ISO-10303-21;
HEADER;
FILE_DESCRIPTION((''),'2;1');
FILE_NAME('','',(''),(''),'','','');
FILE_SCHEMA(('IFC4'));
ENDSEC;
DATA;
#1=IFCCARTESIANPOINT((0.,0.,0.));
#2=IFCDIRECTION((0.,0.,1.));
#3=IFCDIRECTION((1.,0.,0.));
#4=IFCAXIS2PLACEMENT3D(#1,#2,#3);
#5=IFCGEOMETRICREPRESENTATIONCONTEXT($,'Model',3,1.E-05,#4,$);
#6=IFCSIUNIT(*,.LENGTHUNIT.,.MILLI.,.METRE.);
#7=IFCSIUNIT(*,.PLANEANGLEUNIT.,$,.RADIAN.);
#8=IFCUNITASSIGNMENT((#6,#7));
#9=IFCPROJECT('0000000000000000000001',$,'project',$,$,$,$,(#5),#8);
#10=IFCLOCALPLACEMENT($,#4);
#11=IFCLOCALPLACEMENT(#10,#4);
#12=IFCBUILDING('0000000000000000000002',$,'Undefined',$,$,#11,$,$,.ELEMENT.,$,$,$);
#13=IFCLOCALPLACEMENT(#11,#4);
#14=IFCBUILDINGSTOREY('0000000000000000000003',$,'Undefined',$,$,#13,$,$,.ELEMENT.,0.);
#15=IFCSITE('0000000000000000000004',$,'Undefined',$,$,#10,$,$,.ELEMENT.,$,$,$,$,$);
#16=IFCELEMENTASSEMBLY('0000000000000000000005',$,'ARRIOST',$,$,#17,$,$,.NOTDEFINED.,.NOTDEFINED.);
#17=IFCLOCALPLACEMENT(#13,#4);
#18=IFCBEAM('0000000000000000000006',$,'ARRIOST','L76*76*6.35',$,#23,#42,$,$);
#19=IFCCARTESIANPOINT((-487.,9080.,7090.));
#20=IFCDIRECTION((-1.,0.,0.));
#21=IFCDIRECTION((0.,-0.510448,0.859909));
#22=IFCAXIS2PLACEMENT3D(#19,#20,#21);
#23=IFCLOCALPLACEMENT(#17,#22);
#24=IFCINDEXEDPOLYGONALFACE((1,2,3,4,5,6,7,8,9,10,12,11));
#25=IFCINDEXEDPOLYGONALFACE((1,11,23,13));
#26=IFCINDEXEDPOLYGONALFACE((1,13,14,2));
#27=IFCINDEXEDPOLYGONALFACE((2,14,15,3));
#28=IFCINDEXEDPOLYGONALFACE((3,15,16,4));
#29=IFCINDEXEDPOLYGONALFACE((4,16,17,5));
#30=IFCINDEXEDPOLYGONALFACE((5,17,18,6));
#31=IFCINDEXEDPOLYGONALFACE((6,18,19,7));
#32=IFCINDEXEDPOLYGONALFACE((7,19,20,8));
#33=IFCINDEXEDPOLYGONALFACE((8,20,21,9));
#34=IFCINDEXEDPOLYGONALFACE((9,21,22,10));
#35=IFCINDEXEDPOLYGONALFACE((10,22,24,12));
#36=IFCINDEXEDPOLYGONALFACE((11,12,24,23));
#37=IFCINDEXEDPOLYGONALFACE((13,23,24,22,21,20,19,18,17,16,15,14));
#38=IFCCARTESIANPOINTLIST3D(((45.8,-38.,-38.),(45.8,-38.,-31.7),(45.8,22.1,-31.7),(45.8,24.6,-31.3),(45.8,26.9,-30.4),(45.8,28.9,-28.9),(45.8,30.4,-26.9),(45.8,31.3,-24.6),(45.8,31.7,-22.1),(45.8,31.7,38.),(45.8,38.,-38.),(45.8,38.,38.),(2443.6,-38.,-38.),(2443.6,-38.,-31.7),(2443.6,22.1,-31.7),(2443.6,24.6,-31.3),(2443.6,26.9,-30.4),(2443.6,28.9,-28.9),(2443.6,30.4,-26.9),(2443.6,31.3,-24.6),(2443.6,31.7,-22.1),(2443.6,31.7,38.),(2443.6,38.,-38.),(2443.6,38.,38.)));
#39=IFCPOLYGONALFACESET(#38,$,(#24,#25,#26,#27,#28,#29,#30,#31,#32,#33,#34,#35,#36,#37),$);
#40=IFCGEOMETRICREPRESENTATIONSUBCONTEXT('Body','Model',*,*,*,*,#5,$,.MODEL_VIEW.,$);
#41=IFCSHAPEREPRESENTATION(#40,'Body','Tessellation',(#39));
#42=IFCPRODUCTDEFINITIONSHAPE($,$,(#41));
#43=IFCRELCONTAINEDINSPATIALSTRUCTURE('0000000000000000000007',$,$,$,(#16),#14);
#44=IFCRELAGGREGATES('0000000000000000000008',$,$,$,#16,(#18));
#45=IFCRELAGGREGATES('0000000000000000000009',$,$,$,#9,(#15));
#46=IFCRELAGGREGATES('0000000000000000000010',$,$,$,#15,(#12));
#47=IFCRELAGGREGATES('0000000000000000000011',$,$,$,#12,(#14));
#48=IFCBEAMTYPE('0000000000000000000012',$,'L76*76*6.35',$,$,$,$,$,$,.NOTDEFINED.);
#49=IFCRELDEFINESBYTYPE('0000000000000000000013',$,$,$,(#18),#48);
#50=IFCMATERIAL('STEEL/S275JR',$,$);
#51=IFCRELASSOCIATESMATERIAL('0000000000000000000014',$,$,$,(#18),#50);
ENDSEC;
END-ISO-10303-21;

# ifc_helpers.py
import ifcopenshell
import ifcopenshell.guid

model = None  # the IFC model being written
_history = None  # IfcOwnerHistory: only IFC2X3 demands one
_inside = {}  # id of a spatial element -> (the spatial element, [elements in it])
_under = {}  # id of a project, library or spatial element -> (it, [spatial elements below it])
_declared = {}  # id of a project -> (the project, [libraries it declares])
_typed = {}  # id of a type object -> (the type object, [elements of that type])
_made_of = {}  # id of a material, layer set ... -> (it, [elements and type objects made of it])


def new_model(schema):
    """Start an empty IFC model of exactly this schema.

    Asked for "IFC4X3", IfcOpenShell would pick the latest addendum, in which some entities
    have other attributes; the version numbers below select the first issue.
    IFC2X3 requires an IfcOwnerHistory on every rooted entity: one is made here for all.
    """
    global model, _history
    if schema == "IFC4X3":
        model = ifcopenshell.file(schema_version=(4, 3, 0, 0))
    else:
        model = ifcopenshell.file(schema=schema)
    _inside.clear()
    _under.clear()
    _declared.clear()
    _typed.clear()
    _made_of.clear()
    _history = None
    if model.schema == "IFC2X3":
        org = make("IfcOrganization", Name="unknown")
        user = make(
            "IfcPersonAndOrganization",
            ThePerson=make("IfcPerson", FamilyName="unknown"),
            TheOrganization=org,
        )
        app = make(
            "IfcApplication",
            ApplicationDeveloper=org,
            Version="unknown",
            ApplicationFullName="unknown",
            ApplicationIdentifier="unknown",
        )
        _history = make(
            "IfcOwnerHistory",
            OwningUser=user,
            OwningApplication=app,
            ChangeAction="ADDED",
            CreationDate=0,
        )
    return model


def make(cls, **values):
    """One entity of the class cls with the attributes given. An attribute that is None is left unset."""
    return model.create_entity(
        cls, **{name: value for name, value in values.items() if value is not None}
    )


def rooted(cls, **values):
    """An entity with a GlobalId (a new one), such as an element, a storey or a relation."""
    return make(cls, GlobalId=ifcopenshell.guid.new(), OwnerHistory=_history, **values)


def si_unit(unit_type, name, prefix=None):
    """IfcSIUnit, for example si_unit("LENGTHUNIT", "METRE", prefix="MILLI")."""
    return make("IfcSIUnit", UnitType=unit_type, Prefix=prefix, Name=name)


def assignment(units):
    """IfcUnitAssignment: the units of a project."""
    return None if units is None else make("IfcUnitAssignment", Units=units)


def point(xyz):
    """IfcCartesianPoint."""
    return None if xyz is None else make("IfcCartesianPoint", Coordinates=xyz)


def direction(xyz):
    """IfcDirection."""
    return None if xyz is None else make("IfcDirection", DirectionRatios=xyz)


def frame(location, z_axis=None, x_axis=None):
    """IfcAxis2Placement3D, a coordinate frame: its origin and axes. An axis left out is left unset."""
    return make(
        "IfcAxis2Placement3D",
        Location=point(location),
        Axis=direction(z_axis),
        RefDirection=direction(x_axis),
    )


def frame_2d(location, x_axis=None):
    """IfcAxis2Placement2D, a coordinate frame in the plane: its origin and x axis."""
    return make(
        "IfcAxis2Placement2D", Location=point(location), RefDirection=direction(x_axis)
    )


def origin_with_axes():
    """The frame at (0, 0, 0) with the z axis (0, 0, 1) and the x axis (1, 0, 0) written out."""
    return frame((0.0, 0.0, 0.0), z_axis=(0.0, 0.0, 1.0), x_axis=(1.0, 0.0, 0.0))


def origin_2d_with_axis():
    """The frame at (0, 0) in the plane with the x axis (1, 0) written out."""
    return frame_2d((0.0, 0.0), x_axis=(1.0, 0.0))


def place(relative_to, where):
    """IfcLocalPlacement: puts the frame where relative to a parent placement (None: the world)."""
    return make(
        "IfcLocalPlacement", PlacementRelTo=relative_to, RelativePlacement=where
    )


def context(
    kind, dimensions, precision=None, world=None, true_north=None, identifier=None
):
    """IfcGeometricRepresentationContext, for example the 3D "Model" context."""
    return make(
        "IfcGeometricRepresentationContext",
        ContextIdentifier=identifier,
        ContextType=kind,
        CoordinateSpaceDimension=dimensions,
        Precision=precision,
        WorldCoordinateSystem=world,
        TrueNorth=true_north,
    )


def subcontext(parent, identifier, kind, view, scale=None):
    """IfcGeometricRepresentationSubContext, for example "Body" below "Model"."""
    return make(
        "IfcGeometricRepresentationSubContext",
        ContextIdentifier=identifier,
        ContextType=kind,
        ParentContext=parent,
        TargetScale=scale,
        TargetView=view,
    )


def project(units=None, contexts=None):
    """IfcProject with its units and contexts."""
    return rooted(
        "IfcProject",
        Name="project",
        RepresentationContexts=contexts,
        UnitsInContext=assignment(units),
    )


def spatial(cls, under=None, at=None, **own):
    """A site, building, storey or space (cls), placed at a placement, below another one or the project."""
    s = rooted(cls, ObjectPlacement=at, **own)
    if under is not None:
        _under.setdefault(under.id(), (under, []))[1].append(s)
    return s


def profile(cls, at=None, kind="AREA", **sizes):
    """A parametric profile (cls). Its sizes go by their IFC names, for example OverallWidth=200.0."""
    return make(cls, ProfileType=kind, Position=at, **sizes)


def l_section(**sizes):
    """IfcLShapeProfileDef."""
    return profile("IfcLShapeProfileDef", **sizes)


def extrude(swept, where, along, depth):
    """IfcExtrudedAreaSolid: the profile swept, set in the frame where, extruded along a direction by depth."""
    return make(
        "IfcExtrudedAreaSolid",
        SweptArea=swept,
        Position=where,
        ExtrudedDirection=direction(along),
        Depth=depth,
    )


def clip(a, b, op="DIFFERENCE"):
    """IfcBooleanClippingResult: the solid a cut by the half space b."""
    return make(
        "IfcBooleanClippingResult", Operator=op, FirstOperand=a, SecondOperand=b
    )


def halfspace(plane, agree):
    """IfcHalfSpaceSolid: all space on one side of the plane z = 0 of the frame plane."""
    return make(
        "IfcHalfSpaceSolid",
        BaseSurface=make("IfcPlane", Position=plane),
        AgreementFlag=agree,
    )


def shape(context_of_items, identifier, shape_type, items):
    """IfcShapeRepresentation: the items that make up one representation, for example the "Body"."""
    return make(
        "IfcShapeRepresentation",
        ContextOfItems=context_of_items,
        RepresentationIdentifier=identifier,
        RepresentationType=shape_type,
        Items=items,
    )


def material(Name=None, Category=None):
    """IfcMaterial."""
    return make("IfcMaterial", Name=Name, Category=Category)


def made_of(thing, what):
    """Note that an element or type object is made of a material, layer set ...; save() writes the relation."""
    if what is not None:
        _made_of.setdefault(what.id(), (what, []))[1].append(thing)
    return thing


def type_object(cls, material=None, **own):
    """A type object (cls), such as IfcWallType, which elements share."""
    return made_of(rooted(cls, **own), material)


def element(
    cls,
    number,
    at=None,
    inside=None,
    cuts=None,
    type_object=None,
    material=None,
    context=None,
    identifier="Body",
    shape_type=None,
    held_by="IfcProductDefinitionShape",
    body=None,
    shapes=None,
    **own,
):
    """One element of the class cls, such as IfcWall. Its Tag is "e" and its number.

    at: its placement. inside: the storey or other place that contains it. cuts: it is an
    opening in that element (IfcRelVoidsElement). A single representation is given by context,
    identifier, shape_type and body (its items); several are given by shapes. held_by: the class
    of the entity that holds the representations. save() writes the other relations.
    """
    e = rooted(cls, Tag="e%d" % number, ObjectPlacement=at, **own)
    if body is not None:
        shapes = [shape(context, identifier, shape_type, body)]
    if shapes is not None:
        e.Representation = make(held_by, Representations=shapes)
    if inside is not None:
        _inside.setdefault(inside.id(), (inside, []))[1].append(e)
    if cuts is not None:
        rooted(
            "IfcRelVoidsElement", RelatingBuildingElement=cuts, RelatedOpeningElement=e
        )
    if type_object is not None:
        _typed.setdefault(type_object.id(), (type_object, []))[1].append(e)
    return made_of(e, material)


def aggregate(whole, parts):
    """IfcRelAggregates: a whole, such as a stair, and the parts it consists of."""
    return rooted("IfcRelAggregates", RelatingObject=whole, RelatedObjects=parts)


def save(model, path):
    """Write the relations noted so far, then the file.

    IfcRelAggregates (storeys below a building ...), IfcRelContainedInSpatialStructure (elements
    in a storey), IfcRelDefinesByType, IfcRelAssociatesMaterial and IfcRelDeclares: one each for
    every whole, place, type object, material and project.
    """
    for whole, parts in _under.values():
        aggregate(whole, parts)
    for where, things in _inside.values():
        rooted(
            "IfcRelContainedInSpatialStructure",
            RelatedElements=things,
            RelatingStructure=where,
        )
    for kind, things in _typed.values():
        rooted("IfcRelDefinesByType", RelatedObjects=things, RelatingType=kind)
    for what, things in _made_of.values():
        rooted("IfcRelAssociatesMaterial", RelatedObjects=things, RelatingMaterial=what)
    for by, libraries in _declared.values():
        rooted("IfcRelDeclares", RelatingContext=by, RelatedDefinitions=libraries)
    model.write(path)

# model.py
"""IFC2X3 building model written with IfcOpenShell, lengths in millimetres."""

from ifc_helpers import new_model, si_unit, frame, origin_with_axes, origin_2d_with_axis, place, context, subcontext, project, spatial, l_section, extrude, clip, halfspace, material, type_object, element, aggregate, save


model = new_model("IFC2X3")

# Units and contexts
model_context = context("Model", 3, precision=1e-05, world=origin_with_axes())
body_context = subcontext(model_context, "Body", "Model", "MODEL_VIEW")
ifc_project = project(units=[si_unit("LENGTHUNIT", "METRE", prefix="MILLI"), si_unit("PLANEANGLEUNIT", "RADIAN")], contexts=[model_context])

# Site, building, storey
site_placement = place(None, origin_with_axes())
site = spatial("IfcSite", under=ifc_project, at=site_placement, Name="Undefined", CompositionType="ELEMENT")
building_placement = place(site_placement, origin_with_axes())
building = spatial("IfcBuilding", under=site, at=building_placement, Name="Undefined", CompositionType="ELEMENT")
storey_placement = place(building_placement, origin_with_axes())
storey = spatial("IfcBuildingStorey", under=building, at=storey_placement, Name="Undefined", CompositionType="ELEMENT", Elevation=0.0)

# Element assembly, beam
assembly_1_placement = place(storey_placement, origin_with_axes())
assembly_1 = element("IfcElementAssembly", 1, at=assembly_1_placement, inside=storey, Name="ARRIOST", AssemblyPlace="NOTDEFINED", PredefinedType="NOTDEFINED")
ifc_material_1 = material(Name="STEEL/S275JR")
beam_type_1 = type_object("IfcBeamType", Name="L76*76*6.35", PredefinedType="NOTDEFINED")
beam_1_placement = place(assembly_1_placement, frame((-487.0, 9080.0, 7090.0), z_axis=(-1.0, 0.0, 0.0), x_axis=(0.0, -0.510448, 0.859909)))
beam_1 = element("IfcBeam", 2, at=beam_1_placement, type_object=beam_type_1, material=ifc_material_1, Name="ARRIOST", Description="L76*76*6.35", context=body_context, shape_type="Clipping", body=[
    clip(clip(extrude(l_section(Depth=76.0, Width=76.0, Thickness=6.3, FilletRadius=9.5, at=origin_2d_with_axis()), frame((2546.8, 0.0, 0.0), z_axis=(-1.0, 0.0, 0.0), x_axis=(0.0, -1.0, 0.0)), (0.0, 0.0, 1.0), 2568.3), halfspace(frame((2443.6, 0.0, -38.0), z_axis=(-1.0, 0.0, 0.0), x_axis=(0.0, -1.0, 0.0)), True)), halfspace(frame((45.8, 0.0, -38.0), z_axis=(1.0, 0.0, 0.0), x_axis=(0.0, 1.0, 0.0)), True)),
])

aggregate(assembly_1, [beam_1])

save(model, "model.ifc")
